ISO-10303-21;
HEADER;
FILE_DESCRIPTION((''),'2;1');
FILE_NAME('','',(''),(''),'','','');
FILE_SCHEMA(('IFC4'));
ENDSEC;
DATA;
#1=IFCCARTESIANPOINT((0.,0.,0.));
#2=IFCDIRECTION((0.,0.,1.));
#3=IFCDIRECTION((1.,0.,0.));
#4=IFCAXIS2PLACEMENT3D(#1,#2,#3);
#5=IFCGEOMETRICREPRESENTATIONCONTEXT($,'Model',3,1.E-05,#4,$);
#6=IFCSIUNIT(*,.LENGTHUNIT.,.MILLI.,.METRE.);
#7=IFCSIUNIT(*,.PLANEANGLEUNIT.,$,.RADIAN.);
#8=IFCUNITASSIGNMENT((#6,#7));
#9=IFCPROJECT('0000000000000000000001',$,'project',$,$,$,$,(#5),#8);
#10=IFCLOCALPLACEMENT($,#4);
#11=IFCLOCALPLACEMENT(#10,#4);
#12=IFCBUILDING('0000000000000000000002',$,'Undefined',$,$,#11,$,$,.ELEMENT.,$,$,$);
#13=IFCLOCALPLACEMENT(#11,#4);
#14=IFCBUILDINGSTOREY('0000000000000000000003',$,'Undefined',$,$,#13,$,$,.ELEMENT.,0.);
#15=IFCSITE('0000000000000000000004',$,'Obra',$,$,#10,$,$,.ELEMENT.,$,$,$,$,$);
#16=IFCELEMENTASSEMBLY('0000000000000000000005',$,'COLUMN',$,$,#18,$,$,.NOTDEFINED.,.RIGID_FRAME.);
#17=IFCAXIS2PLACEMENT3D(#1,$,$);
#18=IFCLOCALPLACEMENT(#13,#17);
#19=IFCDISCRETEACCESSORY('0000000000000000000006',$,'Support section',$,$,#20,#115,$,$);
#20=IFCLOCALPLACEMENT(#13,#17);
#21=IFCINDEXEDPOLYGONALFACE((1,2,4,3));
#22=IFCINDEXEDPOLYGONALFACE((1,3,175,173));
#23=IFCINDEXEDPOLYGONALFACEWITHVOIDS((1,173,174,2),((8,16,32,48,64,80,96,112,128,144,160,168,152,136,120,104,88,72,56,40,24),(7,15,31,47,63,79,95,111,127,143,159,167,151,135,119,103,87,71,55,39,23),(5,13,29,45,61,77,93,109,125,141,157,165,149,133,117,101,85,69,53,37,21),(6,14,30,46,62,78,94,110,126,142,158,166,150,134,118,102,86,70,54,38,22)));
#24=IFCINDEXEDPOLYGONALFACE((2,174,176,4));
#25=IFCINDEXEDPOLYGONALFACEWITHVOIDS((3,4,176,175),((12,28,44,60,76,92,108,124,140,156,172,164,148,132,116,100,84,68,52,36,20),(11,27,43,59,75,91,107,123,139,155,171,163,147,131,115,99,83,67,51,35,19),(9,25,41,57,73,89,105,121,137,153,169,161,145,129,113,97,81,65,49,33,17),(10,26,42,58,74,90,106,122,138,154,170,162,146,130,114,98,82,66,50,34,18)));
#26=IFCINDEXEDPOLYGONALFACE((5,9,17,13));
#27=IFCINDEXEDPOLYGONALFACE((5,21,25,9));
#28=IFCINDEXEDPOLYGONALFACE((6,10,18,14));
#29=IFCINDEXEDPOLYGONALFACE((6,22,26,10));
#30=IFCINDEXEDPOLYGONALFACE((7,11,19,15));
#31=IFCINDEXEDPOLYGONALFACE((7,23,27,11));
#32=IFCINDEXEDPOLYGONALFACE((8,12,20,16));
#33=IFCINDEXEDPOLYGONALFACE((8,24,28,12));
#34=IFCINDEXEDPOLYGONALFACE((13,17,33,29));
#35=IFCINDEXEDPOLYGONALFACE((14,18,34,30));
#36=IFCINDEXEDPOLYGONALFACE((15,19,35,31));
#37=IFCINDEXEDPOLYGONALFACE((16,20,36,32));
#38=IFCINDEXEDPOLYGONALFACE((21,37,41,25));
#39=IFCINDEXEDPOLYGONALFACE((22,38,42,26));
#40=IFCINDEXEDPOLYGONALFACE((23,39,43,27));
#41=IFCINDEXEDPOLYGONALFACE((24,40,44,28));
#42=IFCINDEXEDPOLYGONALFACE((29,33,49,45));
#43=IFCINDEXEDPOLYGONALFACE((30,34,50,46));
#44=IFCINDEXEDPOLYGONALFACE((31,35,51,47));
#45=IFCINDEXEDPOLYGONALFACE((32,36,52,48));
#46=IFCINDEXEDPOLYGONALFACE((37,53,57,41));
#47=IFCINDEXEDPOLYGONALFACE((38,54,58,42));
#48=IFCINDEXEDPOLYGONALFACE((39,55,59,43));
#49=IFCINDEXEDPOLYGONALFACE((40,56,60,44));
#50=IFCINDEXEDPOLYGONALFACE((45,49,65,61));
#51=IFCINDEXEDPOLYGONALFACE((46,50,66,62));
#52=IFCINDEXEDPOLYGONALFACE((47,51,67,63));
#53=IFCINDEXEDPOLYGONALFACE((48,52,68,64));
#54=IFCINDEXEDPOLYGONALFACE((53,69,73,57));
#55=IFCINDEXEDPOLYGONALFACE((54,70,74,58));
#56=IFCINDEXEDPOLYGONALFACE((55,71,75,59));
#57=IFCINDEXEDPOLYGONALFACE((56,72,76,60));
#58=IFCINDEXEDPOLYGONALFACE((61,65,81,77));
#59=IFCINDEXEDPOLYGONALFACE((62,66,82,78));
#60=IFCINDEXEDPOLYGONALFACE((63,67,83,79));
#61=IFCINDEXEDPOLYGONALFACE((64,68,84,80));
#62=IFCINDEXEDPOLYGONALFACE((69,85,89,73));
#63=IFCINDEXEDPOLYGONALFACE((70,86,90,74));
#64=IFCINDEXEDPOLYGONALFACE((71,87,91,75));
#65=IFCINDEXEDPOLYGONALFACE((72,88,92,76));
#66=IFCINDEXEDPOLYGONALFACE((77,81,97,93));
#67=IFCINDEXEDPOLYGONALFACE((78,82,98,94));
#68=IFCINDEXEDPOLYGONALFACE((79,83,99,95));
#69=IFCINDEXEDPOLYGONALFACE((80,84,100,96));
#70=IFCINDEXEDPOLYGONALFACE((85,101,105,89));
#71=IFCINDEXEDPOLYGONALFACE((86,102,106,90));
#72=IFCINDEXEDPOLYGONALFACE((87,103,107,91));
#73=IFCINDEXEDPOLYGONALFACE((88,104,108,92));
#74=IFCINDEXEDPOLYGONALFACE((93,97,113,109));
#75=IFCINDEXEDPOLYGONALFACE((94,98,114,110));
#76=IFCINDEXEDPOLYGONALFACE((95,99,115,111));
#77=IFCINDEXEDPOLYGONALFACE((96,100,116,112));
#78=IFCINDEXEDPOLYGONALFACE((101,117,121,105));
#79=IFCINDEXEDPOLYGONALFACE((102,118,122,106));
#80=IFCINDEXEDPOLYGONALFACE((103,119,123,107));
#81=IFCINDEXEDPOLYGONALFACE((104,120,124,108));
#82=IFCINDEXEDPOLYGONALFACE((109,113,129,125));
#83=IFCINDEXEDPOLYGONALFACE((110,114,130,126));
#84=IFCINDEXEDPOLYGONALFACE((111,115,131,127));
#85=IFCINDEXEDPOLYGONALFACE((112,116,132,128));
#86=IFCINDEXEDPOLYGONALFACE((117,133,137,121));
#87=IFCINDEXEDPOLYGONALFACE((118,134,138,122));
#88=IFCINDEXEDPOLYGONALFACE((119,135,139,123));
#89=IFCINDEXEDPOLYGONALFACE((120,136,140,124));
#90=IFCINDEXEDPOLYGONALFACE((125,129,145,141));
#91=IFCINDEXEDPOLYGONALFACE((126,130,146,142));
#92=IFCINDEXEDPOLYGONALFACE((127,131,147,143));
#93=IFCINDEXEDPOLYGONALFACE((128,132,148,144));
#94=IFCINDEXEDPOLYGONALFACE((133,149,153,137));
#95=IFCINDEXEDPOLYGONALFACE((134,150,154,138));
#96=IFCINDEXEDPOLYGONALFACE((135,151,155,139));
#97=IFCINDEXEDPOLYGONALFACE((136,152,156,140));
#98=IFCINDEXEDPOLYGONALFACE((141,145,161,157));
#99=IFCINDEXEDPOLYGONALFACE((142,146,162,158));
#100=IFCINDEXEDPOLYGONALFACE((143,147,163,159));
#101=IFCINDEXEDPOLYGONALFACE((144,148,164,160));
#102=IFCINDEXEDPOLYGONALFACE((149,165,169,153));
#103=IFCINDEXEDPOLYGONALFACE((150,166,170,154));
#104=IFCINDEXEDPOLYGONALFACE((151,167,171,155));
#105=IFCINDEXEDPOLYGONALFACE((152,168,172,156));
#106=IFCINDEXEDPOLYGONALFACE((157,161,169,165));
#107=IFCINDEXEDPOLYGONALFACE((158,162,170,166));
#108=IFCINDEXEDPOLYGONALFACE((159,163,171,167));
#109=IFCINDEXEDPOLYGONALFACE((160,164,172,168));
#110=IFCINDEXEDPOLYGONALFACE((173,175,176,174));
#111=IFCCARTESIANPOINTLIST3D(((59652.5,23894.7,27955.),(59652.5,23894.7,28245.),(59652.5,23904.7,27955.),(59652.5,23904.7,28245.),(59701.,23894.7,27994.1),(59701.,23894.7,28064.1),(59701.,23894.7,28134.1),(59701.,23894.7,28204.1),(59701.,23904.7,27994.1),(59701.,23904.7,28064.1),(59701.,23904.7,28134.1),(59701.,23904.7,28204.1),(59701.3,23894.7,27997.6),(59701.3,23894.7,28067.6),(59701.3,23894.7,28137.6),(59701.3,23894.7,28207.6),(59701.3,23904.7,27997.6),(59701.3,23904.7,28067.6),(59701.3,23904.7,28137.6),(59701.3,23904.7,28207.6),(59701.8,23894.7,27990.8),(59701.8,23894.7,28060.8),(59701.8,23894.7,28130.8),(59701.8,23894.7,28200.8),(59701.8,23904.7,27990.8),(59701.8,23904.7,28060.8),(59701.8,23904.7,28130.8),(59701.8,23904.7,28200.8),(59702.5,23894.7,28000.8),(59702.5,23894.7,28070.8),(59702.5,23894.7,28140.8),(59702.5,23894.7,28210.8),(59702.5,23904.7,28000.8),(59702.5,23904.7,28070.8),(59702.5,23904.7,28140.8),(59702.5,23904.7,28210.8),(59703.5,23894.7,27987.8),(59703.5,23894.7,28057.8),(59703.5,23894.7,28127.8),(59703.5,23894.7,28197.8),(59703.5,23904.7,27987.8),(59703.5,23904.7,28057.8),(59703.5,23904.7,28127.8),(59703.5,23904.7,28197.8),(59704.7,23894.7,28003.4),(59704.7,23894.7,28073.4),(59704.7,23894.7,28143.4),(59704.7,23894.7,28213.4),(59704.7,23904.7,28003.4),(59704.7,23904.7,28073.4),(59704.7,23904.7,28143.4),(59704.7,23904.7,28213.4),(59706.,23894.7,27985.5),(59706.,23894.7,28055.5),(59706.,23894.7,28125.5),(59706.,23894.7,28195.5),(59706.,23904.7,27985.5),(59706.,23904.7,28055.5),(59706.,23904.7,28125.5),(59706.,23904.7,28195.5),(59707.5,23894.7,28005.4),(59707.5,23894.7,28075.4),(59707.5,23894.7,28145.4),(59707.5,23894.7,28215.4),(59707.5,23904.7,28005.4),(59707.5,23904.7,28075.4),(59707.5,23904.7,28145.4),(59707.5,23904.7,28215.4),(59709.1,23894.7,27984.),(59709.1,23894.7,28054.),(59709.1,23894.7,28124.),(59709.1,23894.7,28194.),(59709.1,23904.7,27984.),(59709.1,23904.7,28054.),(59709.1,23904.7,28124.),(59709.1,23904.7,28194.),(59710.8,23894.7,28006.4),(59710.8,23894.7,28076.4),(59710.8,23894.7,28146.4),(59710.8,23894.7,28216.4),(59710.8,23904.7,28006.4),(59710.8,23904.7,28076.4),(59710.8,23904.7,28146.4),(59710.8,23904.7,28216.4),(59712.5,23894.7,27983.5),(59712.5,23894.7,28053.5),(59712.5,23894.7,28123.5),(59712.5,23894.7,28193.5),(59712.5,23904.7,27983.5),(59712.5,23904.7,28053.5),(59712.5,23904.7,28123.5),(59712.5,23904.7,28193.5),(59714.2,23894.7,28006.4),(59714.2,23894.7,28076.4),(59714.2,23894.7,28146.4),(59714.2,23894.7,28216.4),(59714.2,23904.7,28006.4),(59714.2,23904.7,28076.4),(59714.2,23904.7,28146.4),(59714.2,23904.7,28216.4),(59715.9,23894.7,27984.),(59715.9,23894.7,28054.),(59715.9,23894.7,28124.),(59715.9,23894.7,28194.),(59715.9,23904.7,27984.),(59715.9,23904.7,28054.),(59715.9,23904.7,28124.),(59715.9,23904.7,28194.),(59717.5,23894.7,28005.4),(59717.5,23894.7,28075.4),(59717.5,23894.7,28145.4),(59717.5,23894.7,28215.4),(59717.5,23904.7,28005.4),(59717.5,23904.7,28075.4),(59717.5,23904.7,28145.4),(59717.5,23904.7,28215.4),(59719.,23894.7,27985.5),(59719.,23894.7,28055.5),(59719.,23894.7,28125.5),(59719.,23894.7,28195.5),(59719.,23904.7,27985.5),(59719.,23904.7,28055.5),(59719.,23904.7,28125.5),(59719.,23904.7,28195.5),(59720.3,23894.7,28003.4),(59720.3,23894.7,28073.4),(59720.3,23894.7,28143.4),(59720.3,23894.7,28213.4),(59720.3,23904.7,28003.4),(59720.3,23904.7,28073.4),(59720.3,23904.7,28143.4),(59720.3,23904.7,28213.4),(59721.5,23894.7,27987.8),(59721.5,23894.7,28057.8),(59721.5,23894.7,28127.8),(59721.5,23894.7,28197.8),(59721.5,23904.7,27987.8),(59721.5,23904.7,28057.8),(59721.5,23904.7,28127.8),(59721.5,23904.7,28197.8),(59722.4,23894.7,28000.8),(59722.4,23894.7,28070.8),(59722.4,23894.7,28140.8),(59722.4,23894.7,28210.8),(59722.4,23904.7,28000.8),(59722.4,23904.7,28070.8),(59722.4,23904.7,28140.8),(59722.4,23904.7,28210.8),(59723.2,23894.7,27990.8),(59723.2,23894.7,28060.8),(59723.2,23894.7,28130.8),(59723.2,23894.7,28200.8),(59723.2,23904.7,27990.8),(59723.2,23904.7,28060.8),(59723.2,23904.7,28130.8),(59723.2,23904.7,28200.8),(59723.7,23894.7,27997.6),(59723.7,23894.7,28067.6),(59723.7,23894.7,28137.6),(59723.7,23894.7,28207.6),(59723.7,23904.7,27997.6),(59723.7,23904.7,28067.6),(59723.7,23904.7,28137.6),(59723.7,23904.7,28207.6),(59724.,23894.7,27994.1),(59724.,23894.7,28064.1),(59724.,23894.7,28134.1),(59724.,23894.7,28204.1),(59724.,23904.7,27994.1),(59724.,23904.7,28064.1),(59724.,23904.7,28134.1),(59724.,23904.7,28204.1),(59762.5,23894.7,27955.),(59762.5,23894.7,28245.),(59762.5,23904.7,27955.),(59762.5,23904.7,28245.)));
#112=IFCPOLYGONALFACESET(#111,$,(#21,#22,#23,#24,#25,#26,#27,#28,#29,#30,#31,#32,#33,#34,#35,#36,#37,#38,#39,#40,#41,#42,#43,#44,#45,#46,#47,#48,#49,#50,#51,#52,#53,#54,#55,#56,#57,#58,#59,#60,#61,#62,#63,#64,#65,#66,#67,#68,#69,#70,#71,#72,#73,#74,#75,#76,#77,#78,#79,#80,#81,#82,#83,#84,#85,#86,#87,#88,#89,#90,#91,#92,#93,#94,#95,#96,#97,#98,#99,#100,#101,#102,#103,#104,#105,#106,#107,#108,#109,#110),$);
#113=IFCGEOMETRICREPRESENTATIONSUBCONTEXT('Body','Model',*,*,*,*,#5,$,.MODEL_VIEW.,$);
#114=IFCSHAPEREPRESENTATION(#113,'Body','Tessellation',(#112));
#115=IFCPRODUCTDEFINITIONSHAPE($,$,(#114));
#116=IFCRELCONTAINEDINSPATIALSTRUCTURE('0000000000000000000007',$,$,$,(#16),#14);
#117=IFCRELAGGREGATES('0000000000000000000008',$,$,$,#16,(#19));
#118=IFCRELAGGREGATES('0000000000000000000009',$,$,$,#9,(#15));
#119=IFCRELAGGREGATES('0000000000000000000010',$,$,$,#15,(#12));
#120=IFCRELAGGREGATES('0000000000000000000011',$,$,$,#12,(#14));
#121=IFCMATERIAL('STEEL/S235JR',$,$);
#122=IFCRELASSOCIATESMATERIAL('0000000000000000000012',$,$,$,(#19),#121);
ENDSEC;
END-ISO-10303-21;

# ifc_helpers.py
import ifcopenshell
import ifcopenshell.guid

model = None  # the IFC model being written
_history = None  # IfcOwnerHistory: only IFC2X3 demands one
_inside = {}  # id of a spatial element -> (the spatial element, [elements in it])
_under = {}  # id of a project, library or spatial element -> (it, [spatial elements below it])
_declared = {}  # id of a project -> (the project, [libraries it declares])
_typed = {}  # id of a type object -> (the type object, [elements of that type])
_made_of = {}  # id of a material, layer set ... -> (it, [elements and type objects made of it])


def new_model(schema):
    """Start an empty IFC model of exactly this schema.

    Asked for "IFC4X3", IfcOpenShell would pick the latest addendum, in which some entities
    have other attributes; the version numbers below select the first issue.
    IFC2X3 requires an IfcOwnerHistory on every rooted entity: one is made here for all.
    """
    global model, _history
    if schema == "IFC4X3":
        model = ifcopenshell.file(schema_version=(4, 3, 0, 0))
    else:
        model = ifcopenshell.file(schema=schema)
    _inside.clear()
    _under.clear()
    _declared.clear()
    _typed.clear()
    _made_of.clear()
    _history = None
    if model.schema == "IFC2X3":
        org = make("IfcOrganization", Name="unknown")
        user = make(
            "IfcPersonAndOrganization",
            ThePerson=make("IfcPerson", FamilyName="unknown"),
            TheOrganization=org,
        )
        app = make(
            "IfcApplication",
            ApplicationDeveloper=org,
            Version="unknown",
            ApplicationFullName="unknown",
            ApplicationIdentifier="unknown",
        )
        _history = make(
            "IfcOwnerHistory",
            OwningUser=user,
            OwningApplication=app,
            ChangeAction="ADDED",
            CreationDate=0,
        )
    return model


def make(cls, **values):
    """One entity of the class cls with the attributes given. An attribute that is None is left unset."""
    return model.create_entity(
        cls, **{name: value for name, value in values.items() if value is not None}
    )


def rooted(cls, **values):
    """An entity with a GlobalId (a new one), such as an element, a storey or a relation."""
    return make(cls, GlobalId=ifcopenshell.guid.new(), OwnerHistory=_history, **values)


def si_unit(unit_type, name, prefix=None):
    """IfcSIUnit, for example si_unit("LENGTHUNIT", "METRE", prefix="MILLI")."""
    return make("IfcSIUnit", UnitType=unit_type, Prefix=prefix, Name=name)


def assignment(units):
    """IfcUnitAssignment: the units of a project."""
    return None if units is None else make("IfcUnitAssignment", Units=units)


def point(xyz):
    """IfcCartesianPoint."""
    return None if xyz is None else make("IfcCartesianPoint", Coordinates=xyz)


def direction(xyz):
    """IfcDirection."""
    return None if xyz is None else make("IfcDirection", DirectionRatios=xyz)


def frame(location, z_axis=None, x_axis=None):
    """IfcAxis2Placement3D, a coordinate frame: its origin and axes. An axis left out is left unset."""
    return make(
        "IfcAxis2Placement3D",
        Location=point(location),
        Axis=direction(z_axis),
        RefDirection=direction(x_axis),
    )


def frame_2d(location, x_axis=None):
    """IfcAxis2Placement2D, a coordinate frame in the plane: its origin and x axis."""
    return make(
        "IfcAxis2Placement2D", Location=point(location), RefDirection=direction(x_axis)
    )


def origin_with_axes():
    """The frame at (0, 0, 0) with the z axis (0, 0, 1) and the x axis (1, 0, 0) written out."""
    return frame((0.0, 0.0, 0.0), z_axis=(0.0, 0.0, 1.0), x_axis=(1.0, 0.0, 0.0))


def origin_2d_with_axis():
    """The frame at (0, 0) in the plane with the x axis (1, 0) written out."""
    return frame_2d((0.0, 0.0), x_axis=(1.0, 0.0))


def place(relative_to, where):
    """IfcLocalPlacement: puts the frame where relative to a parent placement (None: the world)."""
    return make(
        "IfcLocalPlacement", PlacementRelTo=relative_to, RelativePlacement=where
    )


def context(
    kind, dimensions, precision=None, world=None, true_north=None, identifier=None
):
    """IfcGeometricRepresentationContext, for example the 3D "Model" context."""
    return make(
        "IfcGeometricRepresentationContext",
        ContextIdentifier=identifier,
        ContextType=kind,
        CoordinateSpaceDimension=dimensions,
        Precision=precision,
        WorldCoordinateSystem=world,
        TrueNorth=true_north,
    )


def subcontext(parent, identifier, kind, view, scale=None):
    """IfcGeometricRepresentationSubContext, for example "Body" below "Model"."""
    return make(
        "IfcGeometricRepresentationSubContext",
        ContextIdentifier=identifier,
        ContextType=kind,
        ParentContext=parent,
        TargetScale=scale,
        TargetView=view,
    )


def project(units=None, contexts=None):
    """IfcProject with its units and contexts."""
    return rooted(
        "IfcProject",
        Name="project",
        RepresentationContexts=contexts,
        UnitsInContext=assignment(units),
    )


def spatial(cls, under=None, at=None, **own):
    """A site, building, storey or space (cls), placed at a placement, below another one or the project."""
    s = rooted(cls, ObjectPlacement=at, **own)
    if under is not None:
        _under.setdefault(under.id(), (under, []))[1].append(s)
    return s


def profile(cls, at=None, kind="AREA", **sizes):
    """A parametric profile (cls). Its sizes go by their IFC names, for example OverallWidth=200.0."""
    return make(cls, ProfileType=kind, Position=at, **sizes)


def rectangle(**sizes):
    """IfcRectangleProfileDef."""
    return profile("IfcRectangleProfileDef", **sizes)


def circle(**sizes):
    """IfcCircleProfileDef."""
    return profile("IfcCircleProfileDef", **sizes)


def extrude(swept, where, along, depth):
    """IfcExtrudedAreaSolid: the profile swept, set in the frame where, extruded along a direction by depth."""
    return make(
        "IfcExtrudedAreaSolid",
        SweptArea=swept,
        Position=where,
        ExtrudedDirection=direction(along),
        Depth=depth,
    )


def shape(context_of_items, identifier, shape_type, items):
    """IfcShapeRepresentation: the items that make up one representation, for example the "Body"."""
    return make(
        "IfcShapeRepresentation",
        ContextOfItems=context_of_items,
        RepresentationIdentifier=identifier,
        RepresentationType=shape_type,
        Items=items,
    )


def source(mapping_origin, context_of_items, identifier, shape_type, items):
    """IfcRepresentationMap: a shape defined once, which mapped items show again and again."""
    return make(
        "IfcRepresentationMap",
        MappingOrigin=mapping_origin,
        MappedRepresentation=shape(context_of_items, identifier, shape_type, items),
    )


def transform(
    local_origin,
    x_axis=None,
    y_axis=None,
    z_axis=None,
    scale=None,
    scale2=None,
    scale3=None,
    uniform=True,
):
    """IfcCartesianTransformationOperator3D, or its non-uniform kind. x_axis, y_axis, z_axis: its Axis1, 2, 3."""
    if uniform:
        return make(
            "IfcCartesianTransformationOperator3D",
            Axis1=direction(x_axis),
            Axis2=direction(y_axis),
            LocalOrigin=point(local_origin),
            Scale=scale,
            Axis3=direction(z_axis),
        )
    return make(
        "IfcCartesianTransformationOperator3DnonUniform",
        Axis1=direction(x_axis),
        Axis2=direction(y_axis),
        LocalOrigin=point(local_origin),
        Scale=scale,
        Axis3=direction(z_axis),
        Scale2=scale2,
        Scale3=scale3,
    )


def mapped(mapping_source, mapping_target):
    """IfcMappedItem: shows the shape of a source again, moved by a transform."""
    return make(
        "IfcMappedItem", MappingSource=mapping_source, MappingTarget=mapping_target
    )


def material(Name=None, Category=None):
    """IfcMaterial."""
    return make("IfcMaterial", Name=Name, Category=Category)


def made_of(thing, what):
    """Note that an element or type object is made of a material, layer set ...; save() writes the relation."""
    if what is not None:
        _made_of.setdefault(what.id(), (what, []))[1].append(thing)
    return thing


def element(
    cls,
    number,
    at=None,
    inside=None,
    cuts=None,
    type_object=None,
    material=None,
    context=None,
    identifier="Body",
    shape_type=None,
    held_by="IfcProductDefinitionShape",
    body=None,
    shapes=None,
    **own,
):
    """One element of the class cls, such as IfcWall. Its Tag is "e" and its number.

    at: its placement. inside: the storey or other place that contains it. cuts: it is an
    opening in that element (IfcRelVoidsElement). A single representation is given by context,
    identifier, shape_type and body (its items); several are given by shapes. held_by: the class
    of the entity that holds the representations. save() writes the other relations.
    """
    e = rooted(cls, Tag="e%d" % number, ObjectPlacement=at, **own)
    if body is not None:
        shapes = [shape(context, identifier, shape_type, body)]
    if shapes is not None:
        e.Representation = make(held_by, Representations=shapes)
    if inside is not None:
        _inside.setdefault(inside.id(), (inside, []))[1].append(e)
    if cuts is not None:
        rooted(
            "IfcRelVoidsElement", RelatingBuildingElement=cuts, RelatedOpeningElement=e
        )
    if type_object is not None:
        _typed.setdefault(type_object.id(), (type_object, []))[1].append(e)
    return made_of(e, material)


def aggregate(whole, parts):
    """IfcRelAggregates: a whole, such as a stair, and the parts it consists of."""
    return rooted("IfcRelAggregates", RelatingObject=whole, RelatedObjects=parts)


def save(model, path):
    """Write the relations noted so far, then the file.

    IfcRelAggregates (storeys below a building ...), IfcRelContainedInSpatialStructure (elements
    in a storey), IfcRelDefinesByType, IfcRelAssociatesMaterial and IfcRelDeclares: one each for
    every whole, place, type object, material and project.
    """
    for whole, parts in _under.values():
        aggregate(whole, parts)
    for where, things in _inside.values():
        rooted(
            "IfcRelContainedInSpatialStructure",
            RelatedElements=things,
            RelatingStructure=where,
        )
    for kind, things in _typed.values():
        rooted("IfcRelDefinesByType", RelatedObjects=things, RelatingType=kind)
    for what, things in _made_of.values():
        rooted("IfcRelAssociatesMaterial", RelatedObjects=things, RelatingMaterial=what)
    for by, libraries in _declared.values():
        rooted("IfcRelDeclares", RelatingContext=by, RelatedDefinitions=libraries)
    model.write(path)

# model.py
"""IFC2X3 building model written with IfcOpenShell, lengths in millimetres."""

from ifc_helpers import new_model, si_unit, frame, origin_with_axes, origin_2d_with_axis, place, context, subcontext, project, spatial, rectangle, circle, extrude, source, transform, mapped, material, element, aggregate, save


model = new_model("IFC2X3")

# Units and contexts
model_context = context("Model", 3, precision=1e-05, world=origin_with_axes())
body_context = subcontext(model_context, "Body", "Model", "MODEL_VIEW")
ifc_project = project(units=[si_unit("LENGTHUNIT", "METRE", prefix="MILLI"), si_unit("PLANEANGLEUNIT", "RADIAN")], contexts=[model_context])

# Site, building, storey
site_placement = place(None, origin_with_axes())
site = spatial("IfcSite", under=ifc_project, at=site_placement, Name="Obra", CompositionType="ELEMENT")
building_placement = place(site_placement, origin_with_axes())
building = spatial("IfcBuilding", under=site, at=building_placement, Name="Undefined", CompositionType="ELEMENT")
storey_placement = place(building_placement, origin_with_axes())
storey = spatial("IfcBuildingStorey", under=building, at=storey_placement, Name="Undefined", CompositionType="ELEMENT", Elevation=0.0)

# Element assembly
ifc_material_1 = material(Name="STEEL/S235JR")
assembly_1_placement = place(storey_placement, origin_with_axes())
assembly_1 = element("IfcElementAssembly", 1, at=assembly_1_placement, inside=storey, Name="COLUMN", AssemblyPlace="NOTDEFINED", PredefinedType="RIGID_FRAME")

# Discrete accessory, opening
shared_shape_1 = source(origin_with_axes(), body_context, "Body", "SweptSolid", [
    extrude(circle(Radius=11.5, at=origin_2d_with_axis()), frame((0.0, -14.4, 0.0), z_axis=(0.0, 1.0, 0.0), x_axis=(1.0, 0.0, 0.0)), (0.0, 0.0, 1.0), 10.2),
])
discrete_accessory_1_placement = place(assembly_1_placement, frame((59707.5, 23899.7, 27955.0), z_axis=(0.0, 0.0, 1.0), x_axis=(-1.0, 0.0, 0.0)))
discrete_accessory_1 = element("IfcDiscreteAccessory", 2, at=discrete_accessory_1_placement, material=ifc_material_1, Name="Support section", context=body_context, shape_type="SweptSolid", body=[
    extrude(rectangle(XDim=10.0, YDim=110.0, at=origin_2d_with_axis()), frame((0.0, 0.0, 290.0), z_axis=(0.0, 0.0, -1.0), x_axis=(0.0, 1.0, 0.0)), (0.0, 0.0, 1.0), 290.0),
])
opening_1_placement = place(assembly_1_placement, frame((59662.5, 23909.0, 28300.0), z_axis=(1.0, 0.0, 0.0), x_axis=(0.0, 0.0, -1.0)))
element("IfcOpeningElement", 3, at=opening_1_placement, cuts=discrete_accessory_1, ObjectType="Opening", context=body_context, shape_type="MappedRepresentation", body=[
    mapped(shared_shape_1, transform((95.0, 0.0, 50.0))),
    mapped(shared_shape_1, transform((165.0, 0.0, 50.0))),
    mapped(shared_shape_1, transform((235.0, 0.0, 50.0))),
    mapped(shared_shape_1, transform((305.0, 0.0, 50.0))),
])
aggregate(assembly_1, [discrete_accessory_1])

save(model, "model.ifc")
